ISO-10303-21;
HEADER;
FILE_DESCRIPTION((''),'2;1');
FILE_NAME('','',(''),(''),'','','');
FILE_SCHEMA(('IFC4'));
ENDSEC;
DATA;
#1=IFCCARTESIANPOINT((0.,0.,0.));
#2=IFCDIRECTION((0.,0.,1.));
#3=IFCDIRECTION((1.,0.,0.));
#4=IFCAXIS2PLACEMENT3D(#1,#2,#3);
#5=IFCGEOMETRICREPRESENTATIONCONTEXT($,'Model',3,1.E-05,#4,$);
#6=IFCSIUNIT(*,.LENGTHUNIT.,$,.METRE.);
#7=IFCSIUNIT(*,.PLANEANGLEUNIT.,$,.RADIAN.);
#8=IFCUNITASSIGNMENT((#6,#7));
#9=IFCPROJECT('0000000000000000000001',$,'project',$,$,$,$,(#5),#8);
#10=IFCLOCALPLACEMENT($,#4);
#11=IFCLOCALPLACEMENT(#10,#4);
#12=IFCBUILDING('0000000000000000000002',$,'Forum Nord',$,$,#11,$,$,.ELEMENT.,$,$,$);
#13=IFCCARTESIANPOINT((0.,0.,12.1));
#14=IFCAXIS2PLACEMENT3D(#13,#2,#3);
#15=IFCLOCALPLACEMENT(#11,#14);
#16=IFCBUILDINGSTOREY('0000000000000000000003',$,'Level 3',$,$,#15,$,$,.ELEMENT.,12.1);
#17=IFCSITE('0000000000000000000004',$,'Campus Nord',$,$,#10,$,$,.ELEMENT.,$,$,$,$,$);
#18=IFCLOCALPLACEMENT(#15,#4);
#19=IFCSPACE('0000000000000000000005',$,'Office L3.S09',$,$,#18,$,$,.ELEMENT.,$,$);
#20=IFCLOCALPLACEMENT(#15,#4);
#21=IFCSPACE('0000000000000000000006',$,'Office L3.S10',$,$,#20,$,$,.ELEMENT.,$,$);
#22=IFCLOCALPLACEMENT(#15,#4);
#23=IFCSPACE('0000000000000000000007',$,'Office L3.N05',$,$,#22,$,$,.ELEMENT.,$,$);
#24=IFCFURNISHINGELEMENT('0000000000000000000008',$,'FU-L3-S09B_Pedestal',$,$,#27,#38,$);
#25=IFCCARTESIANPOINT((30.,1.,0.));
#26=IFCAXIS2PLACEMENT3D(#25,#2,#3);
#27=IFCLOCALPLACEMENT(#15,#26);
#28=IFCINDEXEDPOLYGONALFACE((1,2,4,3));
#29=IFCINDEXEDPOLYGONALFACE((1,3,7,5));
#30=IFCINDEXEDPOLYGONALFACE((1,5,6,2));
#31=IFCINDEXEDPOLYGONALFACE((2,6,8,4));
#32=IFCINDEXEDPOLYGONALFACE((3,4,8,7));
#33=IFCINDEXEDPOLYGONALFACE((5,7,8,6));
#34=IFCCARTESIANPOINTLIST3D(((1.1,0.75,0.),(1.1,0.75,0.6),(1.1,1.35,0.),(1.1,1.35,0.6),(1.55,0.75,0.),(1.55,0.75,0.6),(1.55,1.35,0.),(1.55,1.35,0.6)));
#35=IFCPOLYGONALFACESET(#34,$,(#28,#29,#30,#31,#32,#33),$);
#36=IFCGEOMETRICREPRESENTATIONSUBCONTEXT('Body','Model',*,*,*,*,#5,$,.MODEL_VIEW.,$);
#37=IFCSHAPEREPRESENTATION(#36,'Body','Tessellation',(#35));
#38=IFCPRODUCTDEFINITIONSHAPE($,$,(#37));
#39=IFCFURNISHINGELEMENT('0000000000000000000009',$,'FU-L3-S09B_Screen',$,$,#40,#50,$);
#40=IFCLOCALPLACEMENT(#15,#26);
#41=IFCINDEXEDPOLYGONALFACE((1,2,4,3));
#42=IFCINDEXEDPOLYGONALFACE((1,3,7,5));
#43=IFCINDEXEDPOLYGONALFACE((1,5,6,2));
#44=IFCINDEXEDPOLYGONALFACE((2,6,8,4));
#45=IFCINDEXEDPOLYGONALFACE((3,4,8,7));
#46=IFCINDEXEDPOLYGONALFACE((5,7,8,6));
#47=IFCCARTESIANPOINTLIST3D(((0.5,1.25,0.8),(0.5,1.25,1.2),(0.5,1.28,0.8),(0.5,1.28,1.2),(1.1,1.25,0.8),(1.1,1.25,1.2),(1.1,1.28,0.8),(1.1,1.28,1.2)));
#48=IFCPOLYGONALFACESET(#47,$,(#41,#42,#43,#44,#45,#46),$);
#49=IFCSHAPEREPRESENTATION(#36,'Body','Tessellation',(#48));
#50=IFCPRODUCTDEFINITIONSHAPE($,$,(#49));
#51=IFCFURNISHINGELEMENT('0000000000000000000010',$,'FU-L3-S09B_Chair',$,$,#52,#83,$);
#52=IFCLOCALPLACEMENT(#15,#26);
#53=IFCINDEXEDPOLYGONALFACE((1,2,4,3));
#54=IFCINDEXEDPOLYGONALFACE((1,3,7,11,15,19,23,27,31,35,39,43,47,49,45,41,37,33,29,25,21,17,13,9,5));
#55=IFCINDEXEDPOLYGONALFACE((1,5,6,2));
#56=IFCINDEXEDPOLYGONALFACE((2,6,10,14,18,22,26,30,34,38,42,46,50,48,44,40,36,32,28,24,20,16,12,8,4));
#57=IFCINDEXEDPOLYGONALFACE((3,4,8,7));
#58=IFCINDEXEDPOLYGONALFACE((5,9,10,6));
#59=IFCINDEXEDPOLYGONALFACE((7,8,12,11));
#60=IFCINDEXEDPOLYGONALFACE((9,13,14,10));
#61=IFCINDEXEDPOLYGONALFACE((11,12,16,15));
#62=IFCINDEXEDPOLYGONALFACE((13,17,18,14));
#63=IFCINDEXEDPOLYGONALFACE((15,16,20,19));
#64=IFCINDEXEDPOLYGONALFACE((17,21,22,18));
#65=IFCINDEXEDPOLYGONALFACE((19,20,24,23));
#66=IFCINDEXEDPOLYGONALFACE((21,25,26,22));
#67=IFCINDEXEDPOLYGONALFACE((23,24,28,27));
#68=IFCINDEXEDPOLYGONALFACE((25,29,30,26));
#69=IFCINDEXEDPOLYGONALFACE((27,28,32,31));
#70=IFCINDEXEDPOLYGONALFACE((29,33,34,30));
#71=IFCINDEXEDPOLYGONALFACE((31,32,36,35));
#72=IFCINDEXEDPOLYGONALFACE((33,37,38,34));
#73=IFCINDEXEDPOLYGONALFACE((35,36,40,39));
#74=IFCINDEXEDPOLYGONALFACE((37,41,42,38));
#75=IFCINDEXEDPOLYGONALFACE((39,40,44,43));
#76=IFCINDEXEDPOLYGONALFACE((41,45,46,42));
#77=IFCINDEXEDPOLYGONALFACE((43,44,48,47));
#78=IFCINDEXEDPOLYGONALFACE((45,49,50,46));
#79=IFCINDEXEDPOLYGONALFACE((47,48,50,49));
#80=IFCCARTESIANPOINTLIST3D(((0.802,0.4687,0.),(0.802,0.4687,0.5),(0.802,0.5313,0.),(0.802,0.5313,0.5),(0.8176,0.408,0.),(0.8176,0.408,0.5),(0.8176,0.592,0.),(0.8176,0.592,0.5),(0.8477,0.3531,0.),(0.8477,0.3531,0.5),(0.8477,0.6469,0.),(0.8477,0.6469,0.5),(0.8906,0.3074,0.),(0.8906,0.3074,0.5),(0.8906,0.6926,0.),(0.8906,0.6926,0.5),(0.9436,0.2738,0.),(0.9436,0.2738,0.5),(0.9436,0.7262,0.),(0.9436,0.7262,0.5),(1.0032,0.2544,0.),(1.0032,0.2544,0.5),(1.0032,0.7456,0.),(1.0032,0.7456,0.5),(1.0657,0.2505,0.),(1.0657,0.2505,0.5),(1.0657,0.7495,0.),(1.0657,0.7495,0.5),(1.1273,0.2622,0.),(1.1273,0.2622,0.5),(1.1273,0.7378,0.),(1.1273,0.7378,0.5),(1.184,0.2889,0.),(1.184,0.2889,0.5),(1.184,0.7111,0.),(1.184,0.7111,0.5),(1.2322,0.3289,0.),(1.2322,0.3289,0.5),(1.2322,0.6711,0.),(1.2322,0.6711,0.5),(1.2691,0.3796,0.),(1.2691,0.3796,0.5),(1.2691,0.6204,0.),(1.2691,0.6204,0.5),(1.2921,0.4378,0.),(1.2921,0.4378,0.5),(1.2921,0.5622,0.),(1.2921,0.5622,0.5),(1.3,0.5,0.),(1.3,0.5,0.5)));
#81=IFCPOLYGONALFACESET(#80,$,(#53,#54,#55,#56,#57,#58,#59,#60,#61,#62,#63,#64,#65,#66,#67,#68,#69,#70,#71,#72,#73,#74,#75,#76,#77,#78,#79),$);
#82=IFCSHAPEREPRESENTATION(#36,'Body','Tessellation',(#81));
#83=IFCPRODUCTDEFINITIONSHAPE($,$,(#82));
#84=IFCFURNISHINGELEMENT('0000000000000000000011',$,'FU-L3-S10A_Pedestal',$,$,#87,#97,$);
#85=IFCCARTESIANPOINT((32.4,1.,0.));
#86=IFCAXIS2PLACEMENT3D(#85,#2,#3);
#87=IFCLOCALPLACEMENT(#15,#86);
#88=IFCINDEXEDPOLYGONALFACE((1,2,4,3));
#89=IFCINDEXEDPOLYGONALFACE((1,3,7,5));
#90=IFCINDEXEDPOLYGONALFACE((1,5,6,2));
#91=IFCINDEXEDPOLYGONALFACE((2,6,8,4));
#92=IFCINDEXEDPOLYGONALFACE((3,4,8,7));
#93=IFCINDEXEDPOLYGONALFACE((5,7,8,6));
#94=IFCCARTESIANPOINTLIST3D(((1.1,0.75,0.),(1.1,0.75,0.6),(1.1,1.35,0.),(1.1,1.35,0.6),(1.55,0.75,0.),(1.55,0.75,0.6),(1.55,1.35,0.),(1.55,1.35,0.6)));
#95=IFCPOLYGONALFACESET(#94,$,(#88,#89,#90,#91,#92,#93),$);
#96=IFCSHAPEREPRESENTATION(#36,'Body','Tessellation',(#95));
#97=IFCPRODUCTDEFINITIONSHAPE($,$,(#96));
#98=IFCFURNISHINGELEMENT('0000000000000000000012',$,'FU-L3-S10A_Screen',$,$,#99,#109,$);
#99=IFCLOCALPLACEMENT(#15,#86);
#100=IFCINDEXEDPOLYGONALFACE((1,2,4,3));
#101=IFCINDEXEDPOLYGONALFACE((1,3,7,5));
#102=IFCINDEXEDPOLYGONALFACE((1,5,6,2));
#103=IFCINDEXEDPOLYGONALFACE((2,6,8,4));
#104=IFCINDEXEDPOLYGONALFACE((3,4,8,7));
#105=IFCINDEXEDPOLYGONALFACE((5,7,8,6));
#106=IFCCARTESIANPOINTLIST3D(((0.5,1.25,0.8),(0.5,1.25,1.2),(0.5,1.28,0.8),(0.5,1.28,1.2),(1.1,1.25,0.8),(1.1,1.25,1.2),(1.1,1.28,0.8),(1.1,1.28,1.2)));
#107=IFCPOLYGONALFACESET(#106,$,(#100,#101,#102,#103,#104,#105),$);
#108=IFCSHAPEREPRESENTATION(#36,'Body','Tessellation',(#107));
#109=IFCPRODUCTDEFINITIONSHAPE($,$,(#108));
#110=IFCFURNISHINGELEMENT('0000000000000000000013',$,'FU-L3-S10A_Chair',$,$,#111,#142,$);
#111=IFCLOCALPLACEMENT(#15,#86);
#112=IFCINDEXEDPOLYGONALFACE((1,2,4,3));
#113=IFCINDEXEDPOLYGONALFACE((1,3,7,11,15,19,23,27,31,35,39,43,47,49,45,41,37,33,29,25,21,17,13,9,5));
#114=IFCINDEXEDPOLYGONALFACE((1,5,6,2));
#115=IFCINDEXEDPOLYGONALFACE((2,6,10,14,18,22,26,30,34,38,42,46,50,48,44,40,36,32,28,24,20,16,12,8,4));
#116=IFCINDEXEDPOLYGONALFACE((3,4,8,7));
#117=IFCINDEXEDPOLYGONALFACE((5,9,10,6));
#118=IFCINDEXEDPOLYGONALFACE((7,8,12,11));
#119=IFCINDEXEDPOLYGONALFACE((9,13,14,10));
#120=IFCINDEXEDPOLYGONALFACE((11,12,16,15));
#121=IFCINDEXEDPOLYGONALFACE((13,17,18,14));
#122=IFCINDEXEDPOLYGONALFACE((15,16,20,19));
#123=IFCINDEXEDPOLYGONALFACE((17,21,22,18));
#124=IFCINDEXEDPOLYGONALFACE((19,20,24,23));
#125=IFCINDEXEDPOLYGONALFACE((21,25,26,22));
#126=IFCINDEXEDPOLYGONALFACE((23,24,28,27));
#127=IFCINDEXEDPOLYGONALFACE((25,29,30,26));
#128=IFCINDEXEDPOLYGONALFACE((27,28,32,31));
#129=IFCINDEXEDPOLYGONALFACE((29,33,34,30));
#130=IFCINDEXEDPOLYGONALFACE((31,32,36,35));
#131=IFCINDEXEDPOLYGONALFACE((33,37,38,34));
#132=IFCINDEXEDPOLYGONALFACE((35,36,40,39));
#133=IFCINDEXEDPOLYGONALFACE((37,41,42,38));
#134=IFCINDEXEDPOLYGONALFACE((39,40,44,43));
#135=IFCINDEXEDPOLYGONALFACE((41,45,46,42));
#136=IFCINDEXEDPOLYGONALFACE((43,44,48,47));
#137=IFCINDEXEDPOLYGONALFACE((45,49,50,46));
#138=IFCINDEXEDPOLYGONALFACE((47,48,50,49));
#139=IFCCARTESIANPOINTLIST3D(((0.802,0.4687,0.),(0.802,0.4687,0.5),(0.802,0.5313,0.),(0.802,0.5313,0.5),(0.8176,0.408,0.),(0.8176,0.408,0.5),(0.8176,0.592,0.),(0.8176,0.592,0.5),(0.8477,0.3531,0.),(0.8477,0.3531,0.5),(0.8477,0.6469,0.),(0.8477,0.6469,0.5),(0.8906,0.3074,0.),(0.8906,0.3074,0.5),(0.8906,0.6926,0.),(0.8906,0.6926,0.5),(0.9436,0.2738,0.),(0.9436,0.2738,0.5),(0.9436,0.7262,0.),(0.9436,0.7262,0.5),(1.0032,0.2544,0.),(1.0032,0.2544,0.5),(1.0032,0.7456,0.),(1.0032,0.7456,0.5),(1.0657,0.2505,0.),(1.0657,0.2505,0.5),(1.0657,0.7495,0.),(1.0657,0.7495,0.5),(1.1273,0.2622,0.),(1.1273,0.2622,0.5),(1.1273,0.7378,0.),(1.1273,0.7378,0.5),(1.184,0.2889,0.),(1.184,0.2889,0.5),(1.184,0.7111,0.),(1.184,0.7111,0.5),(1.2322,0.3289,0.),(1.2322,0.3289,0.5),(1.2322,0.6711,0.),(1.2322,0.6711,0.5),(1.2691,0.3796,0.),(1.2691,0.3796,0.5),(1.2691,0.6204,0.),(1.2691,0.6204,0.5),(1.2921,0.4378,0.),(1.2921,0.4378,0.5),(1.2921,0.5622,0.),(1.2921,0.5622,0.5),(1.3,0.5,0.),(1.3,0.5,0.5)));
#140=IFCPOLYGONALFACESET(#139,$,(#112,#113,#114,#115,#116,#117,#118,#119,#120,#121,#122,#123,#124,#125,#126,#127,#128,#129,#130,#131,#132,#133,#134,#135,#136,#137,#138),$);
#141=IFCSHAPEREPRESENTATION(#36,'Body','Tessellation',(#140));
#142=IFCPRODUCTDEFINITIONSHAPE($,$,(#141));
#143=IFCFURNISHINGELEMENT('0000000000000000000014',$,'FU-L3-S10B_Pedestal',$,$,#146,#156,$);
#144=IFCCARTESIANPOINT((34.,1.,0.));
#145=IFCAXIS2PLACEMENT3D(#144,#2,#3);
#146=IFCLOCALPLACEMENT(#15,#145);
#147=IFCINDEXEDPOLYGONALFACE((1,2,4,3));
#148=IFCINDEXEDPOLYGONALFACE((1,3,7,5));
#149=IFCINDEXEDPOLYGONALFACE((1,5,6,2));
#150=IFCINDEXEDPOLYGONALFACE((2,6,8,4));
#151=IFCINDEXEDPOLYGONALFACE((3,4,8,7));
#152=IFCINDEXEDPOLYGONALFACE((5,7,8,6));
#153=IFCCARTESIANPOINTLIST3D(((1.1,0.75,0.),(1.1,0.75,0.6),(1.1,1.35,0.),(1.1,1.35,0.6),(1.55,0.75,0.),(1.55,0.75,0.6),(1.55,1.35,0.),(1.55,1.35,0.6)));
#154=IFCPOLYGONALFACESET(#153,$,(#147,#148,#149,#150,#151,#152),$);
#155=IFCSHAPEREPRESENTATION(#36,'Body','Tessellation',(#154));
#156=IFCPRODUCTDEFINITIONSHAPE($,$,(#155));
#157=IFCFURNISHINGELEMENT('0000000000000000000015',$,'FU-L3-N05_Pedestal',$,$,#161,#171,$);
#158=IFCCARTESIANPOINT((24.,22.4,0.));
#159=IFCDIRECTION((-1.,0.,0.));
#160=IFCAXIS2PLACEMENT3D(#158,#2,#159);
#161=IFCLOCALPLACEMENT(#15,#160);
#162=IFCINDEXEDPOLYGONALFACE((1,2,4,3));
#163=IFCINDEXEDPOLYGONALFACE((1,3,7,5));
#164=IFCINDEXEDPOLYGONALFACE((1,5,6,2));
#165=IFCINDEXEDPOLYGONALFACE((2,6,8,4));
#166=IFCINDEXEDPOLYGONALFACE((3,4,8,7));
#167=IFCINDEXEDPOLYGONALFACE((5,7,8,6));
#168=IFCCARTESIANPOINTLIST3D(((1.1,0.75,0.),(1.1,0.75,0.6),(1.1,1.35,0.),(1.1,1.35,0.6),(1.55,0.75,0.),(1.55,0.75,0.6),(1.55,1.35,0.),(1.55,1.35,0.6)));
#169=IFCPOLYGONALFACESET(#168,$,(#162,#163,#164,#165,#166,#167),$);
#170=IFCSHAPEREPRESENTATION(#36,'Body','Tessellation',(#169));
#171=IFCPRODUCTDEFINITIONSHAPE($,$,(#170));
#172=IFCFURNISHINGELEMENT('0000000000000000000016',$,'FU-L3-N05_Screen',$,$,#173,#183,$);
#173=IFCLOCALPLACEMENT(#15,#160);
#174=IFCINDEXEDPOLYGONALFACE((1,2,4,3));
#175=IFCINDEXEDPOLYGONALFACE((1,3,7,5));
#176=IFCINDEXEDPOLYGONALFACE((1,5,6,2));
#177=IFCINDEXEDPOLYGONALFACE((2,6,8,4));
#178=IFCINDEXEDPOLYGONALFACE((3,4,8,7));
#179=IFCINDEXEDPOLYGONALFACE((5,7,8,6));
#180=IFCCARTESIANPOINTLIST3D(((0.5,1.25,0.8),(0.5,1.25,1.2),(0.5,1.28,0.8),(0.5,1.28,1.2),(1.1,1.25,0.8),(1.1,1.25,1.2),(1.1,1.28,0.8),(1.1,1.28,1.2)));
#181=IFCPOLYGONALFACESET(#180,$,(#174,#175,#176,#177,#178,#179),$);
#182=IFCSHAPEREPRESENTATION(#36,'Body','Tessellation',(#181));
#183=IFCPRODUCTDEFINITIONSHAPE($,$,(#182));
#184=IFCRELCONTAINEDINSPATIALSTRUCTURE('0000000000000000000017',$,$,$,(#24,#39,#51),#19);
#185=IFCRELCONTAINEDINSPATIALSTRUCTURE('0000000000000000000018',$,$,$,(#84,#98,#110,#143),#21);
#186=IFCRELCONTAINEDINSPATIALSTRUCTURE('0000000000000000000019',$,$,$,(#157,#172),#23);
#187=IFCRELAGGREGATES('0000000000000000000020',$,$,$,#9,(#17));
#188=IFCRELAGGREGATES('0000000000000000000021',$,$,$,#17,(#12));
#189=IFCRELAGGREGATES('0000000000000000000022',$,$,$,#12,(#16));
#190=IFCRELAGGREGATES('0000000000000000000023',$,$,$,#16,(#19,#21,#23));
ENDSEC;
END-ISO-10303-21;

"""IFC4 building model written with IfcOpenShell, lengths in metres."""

from ifc_helpers import new_model, si_unit, frame, frame_2d, origin_with_axes, place, context, subcontext, project, spatial, rectangle, circle, extrude, element, save


model = new_model("IFC4")

# Units and contexts
model_context = context("Model", 3, precision=1e-05, world=origin_with_axes())
body_context = subcontext(model_context, "Body", "Model", "MODEL_VIEW")
ifc_project = project(units=[si_unit("LENGTHUNIT", "METRE"), si_unit("PLANEANGLEUNIT", "RADIAN")], contexts=[model_context])

# Site, building, storey
site_placement = place(None, origin_with_axes())
site = spatial("IfcSite", under=ifc_project, at=site_placement, Name="Campus Nord", CompositionType="ELEMENT")
building_placement = place(site_placement, origin_with_axes())
building = spatial("IfcBuilding", under=site, at=building_placement, Name="Forum Nord", CompositionType="ELEMENT")
storey_placement = place(building_placement, frame((0.0, 0.0, 12.1), z_axis=(0.0, 0.0, 1.0), x_axis=(1.0, 0.0, 0.0)))
storey = spatial("IfcBuildingStorey", under=building, at=storey_placement, Name="Level 3", CompositionType="ELEMENT", Elevation=12.1)

# Shared definitions
space_1_placement = place(storey_placement, origin_with_axes())
space_1 = spatial("IfcSpace", under=storey, at=space_1_placement, Name="Office L3.S09", CompositionType="ELEMENT")

# Furnishing elements
furnishing_1_placement = place(storey_placement, frame((30.0, 1.0, 0.0), z_axis=(0.0, 0.0, 1.0), x_axis=(1.0, 0.0, 0.0)))
element("IfcFurnishingElement", 1, at=furnishing_1_placement, inside=space_1, Name="FU-L3-S09B_Pedestal", context=body_context, shape_type="SweptSolid", body=[
    extrude(rectangle(XDim=0.45, YDim=0.6, at=frame_2d((1.325, 1.05), x_axis=(1.0, 0.0))), origin_with_axes(), (0.0, 0.0, 1.0), 0.6),
])
furnishing_2_placement = place(storey_placement, frame((30.0, 1.0, 0.0), z_axis=(0.0, 0.0, 1.0), x_axis=(1.0, 0.0, 0.0)))
element("IfcFurnishingElement", 2, at=furnishing_2_placement, inside=space_1, Name="FU-L3-S09B_Screen", context=body_context, shape_type="SweptSolid", body=[
    extrude(rectangle(XDim=0.6, YDim=0.03, at=frame_2d((0.8, 1.265), x_axis=(1.0, 0.0))), frame((0.0, 0.0, 0.8), z_axis=(0.0, 0.0, 1.0), x_axis=(1.0, 0.0, 0.0)), (0.0, 0.0, 1.0), 0.4),
])
furnishing_3_placement = place(storey_placement, frame((30.0, 1.0, 0.0), z_axis=(0.0, 0.0, 1.0), x_axis=(1.0, 0.0, 0.0)))
element("IfcFurnishingElement", 3, at=furnishing_3_placement, inside=space_1, Name="FU-L3-S09B_Chair", context=body_context, shape_type="SweptSolid", body=[
    extrude(circle(Radius=0.25, at=frame_2d((1.05, 0.5), x_axis=(1.0, 0.0))), origin_with_axes(), (0.0, 0.0, 1.0), 0.5),
])

# Shared definitions
space_2_placement = place(storey_placement, origin_with_axes())
space_2 = spatial("IfcSpace", under=storey, at=space_2_placement, Name="Office L3.S10", CompositionType="ELEMENT")

# Furnishing elements
furnishing_4_placement = place(storey_placement, frame((32.4, 1.0, 0.0), z_axis=(0.0, 0.0, 1.0), x_axis=(1.0, 0.0, 0.0)))
element("IfcFurnishingElement", 4, at=furnishing_4_placement, inside=space_2, Name="FU-L3-S10A_Pedestal", context=body_context, shape_type="SweptSolid", body=[
    extrude(rectangle(XDim=0.45, YDim=0.6, at=frame_2d((1.325, 1.05), x_axis=(1.0, 0.0))), origin_with_axes(), (0.0, 0.0, 1.0), 0.6),
])
furnishing_5_placement = place(storey_placement, frame((32.4, 1.0, 0.0), z_axis=(0.0, 0.0, 1.0), x_axis=(1.0, 0.0, 0.0)))
element("IfcFurnishingElement", 5, at=furnishing_5_placement, inside=space_2, Name="FU-L3-S10A_Screen", context=body_context, shape_type="SweptSolid", body=[
    extrude(rectangle(XDim=0.6, YDim=0.03, at=frame_2d((0.8, 1.265), x_axis=(1.0, 0.0))), frame((0.0, 0.0, 0.8), z_axis=(0.0, 0.0, 1.0), x_axis=(1.0, 0.0, 0.0)), (0.0, 0.0, 1.0), 0.4),
])
furnishing_6_placement = place(storey_placement, frame((32.4, 1.0, 0.0), z_axis=(0.0, 0.0, 1.0), x_axis=(1.0, 0.0, 0.0)))
element("IfcFurnishingElement", 6, at=furnishing_6_placement, inside=space_2, Name="FU-L3-S10A_Chair", context=body_context, shape_type="SweptSolid", body=[
    extrude(circle(Radius=0.25, at=frame_2d((1.05, 0.5), x_axis=(1.0, 0.0))), origin_with_axes(), (0.0, 0.0, 1.0), 0.5),
])
furnishing_7_placement = place(storey_placement, frame((34.0, 1.0, 0.0), z_axis=(0.0, 0.0, 1.0), x_axis=(1.0, 0.0, 0.0)))
element("IfcFurnishingElement", 7, at=furnishing_7_placement, inside=space_2, Name="FU-L3-S10B_Pedestal", context=body_context, shape_type="SweptSolid", body=[
    extrude(rectangle(XDim=0.45, YDim=0.6, at=frame_2d((1.325, 1.05), x_axis=(1.0, 0.0))), origin_with_axes(), (0.0, 0.0, 1.0), 0.6),
])

# Shared definitions
space_3_placement = place(storey_placement, origin_with_axes())
space_3 = spatial("IfcSpace", under=storey, at=space_3_placement, Name="Office L3.N05", CompositionType="ELEMENT")

# Furnishing elements
furnishing_8_placement = place(storey_placement, frame((24.0, 22.4, 0.0), z_axis=(0.0, 0.0, 1.0), x_axis=(-1.0, 0.0, 0.0)))
element("IfcFurnishingElement", 8, at=furnishing_8_placement, inside=space_3, Name="FU-L3-N05_Pedestal", context=body_context, shape_type="SweptSolid", body=[
    extrude(rectangle(XDim=0.45, YDim=0.6, at=frame_2d((1.325, 1.05), x_axis=(1.0, 0.0))), origin_with_axes(), (0.0, 0.0, 1.0), 0.6),
])
furnishing_9_placement = place(storey_placement, frame((24.0, 22.4, 0.0), z_axis=(0.0, 0.0, 1.0), x_axis=(-1.0, 0.0, 0.0)))
element("IfcFurnishingElement", 9, at=furnishing_9_placement, inside=space_3, Name="FU-L3-N05_Screen", context=body_context, shape_type="SweptSolid", body=[
    extrude(rectangle(XDim=0.6, YDim=0.03, at=frame_2d((0.8, 1.265), x_axis=(1.0, 0.0))), frame((0.0, 0.0, 0.8), z_axis=(0.0, 0.0, 1.0), x_axis=(1.0, 0.0, 0.0)), (0.0, 0.0, 1.0), 0.4),
])

save(model, "model.ifc")
